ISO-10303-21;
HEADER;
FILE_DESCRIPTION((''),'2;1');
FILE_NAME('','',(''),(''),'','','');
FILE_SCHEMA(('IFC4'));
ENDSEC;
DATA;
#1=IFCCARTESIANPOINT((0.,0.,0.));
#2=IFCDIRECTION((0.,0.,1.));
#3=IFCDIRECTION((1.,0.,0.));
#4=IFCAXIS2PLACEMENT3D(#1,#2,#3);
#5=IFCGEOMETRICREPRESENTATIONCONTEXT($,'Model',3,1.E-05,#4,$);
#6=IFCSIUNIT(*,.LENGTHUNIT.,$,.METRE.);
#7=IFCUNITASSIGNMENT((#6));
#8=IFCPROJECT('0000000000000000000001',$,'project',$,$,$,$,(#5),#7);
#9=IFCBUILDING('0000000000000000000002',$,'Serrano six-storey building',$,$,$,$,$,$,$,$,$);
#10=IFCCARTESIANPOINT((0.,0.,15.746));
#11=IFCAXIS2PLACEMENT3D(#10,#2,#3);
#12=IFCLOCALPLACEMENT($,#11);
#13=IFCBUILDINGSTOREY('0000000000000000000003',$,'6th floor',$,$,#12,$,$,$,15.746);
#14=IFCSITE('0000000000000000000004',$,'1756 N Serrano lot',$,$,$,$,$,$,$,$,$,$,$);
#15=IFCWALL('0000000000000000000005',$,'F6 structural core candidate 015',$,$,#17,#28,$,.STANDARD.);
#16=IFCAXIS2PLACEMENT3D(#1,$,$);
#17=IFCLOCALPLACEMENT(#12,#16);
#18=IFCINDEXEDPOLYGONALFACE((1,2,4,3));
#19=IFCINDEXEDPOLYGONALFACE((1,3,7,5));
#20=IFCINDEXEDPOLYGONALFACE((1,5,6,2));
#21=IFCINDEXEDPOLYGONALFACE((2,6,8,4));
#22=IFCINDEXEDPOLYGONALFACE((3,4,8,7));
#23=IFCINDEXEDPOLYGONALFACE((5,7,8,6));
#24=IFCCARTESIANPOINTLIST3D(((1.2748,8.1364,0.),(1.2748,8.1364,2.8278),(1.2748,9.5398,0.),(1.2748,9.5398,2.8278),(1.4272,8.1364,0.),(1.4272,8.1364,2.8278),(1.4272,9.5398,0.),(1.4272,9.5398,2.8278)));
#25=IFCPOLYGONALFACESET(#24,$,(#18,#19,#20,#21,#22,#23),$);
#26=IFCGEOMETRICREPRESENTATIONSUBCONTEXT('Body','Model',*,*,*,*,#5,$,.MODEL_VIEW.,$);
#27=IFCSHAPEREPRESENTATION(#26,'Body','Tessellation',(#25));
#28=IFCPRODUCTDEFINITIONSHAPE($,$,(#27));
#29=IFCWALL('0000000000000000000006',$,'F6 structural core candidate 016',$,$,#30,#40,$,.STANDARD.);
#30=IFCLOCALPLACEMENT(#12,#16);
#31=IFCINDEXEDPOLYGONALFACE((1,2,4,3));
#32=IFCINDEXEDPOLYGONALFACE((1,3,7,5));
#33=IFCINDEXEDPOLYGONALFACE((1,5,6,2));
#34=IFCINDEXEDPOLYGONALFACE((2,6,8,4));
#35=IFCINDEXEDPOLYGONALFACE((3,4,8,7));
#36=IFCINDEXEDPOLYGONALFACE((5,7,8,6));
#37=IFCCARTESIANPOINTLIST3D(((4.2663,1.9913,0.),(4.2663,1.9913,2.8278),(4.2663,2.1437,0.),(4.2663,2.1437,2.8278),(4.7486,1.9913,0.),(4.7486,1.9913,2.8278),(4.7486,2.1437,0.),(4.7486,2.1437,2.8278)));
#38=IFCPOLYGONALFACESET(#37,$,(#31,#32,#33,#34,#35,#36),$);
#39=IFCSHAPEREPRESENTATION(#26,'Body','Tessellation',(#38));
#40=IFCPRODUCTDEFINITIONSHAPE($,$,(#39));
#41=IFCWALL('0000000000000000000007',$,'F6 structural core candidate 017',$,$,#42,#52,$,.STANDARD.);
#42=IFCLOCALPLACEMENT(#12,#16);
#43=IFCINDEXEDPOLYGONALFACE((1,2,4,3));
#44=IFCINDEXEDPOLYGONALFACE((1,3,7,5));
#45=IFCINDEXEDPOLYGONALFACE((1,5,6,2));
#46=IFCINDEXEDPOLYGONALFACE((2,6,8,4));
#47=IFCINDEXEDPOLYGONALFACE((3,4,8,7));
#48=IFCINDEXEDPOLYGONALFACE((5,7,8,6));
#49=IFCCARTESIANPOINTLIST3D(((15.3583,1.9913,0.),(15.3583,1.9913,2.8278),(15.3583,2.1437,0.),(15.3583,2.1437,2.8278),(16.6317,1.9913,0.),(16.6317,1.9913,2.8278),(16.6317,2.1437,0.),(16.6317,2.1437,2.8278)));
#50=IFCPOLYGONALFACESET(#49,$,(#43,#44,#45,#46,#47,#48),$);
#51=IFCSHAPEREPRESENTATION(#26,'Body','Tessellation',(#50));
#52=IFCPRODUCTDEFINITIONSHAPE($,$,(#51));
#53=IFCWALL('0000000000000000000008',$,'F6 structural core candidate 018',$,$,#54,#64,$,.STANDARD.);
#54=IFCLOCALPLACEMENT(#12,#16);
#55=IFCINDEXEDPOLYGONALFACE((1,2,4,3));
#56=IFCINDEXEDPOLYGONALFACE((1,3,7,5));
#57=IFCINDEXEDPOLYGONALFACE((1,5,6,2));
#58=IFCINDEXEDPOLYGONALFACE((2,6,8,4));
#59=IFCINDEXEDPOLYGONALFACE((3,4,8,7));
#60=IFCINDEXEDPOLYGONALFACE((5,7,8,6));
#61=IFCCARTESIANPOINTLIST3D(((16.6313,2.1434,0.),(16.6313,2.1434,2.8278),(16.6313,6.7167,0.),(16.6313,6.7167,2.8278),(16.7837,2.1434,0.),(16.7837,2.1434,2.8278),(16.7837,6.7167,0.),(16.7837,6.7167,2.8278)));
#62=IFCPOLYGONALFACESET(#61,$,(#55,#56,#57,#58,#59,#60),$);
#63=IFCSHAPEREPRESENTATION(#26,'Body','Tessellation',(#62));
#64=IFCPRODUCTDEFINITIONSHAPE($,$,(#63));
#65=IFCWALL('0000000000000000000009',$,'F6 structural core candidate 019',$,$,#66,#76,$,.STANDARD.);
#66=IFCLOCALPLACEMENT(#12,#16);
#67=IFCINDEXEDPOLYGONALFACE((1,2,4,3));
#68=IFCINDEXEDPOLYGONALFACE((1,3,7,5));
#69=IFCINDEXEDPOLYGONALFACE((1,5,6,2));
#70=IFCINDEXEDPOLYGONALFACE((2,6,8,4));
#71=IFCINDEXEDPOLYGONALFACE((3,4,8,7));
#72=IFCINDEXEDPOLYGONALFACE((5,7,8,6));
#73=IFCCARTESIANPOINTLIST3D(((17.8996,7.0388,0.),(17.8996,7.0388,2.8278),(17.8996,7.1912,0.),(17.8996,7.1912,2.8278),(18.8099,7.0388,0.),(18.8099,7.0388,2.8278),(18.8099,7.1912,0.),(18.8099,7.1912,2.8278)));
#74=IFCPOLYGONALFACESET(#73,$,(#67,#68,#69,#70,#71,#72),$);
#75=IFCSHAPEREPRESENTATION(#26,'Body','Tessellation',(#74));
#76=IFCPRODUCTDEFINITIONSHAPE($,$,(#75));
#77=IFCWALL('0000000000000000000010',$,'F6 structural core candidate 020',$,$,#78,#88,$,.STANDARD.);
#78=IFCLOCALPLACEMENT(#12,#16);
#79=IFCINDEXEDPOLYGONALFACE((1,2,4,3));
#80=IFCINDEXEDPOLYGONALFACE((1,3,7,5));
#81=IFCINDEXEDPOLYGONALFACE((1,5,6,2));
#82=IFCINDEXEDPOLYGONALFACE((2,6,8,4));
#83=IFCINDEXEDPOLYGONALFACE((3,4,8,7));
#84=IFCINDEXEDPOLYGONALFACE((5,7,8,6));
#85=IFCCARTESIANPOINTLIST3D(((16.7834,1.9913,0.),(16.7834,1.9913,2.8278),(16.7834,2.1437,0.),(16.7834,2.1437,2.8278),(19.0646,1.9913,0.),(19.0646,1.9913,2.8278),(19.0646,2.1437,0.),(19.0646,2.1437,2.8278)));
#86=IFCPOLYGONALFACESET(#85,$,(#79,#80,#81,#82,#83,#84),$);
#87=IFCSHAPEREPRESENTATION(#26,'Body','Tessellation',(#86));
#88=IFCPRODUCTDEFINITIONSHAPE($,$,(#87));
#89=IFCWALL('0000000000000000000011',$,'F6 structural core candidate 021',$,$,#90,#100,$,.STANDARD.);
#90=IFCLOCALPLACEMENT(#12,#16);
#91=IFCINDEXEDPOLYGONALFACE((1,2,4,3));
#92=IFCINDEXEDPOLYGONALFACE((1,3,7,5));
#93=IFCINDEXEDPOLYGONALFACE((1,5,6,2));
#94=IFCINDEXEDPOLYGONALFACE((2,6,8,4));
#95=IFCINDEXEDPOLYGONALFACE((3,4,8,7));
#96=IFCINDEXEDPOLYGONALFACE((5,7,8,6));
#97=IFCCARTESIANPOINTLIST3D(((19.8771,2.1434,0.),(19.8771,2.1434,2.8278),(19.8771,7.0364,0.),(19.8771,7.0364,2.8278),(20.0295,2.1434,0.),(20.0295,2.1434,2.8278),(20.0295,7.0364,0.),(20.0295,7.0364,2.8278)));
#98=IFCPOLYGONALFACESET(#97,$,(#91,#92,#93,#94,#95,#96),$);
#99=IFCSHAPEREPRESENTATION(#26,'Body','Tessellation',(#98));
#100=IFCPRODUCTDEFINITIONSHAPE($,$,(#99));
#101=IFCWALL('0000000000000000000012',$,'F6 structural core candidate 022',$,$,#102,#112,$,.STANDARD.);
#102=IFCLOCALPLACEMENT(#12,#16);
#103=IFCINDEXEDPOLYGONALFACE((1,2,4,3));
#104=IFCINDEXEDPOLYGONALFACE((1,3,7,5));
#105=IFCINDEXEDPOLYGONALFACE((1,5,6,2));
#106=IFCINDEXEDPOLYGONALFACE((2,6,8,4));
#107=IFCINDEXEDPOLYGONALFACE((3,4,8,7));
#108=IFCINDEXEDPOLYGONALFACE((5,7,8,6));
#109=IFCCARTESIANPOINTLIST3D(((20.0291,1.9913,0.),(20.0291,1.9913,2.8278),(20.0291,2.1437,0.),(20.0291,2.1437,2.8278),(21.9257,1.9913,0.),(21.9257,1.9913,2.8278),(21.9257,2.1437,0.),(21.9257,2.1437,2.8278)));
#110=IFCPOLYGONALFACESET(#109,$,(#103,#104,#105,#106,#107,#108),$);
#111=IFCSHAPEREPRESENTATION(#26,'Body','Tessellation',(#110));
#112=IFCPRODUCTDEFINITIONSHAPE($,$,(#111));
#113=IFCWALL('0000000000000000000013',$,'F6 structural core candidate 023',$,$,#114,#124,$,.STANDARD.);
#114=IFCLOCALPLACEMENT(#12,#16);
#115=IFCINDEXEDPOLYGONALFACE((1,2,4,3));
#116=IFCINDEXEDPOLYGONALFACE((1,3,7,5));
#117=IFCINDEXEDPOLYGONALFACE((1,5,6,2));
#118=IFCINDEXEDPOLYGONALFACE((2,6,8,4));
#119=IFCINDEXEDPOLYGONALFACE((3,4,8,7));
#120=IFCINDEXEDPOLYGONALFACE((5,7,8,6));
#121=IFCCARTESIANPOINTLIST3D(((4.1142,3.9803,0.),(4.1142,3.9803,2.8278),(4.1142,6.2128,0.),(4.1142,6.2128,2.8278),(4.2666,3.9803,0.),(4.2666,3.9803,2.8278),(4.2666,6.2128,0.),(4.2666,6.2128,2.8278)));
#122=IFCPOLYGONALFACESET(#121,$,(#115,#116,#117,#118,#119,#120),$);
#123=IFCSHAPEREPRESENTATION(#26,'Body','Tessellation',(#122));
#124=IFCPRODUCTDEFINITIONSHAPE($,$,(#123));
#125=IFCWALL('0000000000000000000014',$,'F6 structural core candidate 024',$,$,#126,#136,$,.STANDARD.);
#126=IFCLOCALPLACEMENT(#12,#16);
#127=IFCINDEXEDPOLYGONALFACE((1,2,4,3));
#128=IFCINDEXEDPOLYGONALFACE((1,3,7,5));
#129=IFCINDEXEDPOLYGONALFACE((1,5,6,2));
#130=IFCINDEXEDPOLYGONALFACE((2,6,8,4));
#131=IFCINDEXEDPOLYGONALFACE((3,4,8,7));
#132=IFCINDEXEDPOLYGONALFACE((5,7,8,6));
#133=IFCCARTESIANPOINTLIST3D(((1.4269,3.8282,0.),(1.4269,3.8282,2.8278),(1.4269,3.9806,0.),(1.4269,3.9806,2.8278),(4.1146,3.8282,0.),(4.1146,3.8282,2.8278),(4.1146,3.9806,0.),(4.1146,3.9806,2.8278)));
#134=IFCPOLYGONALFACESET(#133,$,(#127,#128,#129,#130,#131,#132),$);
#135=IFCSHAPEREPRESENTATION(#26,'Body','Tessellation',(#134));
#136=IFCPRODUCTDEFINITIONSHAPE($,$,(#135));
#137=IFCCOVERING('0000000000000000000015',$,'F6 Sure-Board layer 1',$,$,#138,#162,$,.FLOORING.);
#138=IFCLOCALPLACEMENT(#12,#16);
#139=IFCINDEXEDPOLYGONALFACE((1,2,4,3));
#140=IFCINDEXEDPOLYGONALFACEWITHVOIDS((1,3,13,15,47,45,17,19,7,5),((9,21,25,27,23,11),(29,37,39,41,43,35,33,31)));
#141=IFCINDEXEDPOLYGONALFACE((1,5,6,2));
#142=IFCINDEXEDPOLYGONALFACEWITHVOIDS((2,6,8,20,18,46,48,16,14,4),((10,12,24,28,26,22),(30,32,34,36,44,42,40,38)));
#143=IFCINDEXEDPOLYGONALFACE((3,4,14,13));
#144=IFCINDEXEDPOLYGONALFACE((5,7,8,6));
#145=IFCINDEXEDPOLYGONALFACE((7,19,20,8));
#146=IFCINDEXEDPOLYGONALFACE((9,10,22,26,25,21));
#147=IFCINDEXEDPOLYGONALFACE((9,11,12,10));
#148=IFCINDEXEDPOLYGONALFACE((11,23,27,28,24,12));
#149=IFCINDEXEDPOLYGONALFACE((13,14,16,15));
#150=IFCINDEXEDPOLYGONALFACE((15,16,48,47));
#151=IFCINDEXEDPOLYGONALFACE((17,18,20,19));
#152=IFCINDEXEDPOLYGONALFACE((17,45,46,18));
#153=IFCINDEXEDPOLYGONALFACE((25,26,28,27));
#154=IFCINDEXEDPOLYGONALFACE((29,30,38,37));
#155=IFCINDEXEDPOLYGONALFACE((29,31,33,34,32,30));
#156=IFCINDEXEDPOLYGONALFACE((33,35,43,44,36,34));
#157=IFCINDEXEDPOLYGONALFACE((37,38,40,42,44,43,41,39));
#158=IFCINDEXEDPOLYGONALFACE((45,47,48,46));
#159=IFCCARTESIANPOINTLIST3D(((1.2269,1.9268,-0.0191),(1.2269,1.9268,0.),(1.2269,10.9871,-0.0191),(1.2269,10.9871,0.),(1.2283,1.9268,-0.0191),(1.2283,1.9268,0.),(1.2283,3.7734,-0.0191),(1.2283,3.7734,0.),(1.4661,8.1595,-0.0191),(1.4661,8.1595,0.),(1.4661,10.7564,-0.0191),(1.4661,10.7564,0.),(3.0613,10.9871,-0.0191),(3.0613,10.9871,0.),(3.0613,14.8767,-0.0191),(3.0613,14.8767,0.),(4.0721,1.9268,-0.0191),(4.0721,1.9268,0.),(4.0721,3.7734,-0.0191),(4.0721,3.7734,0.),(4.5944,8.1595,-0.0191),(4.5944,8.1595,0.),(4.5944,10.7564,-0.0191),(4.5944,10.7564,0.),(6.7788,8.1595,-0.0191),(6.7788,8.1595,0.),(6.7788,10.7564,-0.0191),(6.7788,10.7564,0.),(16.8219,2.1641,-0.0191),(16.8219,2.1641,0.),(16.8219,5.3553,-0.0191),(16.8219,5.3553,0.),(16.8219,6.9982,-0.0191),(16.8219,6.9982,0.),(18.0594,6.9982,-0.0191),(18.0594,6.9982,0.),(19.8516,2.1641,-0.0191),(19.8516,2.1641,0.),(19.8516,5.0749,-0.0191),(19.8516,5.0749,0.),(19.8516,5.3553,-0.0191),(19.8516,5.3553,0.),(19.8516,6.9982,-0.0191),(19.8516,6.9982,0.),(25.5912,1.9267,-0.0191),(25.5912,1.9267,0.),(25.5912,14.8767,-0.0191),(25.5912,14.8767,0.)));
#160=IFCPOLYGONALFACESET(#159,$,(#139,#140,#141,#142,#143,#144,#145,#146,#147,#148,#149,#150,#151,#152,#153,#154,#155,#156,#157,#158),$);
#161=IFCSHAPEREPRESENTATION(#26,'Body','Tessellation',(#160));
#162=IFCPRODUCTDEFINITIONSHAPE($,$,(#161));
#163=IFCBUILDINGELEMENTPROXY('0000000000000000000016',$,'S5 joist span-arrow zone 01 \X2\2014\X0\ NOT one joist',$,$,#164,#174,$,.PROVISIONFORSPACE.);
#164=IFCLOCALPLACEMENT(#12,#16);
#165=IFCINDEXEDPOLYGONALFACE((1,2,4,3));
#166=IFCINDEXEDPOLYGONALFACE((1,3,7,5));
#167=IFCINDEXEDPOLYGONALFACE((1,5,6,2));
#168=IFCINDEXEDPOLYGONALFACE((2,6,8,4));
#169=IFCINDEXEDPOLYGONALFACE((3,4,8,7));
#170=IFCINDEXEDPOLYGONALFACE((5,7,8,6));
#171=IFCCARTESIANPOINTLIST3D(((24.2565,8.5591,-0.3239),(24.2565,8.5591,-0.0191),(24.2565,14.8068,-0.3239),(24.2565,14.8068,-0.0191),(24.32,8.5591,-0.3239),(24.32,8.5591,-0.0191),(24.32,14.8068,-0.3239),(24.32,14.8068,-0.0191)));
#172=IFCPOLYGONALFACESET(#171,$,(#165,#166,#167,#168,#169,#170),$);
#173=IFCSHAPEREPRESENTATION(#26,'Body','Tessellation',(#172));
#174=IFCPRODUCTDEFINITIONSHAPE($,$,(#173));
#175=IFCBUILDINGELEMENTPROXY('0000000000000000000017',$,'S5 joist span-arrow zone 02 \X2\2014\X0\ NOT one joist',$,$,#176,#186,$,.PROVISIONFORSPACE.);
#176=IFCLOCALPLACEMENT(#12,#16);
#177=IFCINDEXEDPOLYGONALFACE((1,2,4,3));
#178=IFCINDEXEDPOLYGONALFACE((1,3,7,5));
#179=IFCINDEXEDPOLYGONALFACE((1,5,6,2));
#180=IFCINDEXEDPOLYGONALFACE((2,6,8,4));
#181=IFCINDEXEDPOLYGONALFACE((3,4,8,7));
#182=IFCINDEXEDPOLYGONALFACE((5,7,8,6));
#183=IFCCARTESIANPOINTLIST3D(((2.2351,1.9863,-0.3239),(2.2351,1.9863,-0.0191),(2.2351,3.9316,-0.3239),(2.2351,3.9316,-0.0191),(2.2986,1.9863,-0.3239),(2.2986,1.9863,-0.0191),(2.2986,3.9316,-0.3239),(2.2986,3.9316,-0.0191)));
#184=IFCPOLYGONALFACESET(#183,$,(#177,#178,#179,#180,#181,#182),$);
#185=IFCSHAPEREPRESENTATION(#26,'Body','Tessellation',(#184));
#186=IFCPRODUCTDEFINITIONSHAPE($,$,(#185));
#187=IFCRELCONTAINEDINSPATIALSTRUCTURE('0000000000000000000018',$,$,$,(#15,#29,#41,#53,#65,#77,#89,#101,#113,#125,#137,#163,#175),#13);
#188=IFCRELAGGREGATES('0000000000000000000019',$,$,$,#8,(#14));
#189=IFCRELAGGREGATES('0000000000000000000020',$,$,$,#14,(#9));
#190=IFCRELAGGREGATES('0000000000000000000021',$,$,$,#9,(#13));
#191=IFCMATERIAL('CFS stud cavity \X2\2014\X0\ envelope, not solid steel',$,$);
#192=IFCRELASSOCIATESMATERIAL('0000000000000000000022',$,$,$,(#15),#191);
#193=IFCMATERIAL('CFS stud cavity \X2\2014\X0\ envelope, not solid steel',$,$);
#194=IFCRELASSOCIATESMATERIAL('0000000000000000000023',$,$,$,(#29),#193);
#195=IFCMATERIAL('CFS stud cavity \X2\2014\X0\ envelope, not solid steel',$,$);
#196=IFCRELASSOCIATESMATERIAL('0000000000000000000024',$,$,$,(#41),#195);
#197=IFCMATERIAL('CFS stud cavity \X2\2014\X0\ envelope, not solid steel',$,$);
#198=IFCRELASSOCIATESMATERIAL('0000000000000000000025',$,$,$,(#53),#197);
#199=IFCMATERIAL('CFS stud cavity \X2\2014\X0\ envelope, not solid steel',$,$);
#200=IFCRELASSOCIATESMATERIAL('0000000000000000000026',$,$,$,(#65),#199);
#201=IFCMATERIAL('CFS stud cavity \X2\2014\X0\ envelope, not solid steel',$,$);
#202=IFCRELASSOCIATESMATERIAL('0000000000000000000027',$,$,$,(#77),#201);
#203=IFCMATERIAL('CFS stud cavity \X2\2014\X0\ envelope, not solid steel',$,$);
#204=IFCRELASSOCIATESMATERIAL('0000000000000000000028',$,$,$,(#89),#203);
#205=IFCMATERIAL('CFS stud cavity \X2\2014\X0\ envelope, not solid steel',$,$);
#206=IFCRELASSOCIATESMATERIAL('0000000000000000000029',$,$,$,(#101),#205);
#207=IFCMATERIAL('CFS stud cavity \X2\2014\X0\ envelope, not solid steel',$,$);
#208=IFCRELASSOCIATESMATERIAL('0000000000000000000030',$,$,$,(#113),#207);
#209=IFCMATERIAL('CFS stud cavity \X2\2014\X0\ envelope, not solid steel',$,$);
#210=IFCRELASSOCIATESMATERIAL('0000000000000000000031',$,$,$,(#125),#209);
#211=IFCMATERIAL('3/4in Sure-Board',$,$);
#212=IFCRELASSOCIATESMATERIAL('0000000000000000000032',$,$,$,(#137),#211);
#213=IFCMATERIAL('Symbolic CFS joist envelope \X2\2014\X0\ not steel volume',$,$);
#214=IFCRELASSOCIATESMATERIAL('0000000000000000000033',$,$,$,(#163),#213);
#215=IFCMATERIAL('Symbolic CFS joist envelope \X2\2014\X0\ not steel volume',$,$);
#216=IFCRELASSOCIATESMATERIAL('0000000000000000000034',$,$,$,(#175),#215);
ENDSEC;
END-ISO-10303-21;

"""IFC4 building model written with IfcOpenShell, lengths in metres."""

from ifc_helpers import new_model, si_unit, frame, origin_with_axes, place, context, subcontext, project, spatial, polyline, outline, extrude, material, element, save


model = new_model("IFC4")

# Units and contexts
model_context = context("Model", 3, precision=1e-05, world=origin_with_axes())
body_context = subcontext(model_context, "Body", "Model", "MODEL_VIEW")
ifc_project = project(units=[si_unit("LENGTHUNIT", "METRE")], contexts=[model_context])

# Site, building, storey
site = spatial("IfcSite", under=ifc_project, Name="1756 N Serrano lot")
building = spatial("IfcBuilding", under=site, Name="Serrano six-storey building")
storey_placement = place(None, frame((0.0, 0.0, 15.746), z_axis=(0.0, 0.0, 1.0), x_axis=(1.0, 0.0, 0.0)))
storey = spatial("IfcBuildingStorey", under=building, at=storey_placement, Name="6th floor", Elevation=15.746)

# Walls
ifc_material_1 = material(Name="CFS stud cavity — envelope, not solid steel")
wall_1_placement = place(storey_placement, frame((0.0, 0.0, -15.746), z_axis=(0.0, 0.0, 1.0), x_axis=(1.0, 0.0, 0.0)))
element("IfcWall", 1, at=wall_1_placement, inside=storey, material=ifc_material_1, Name="F6 structural core candidate 015", PredefinedType="STANDARD", context=body_context, shape_type="SweptSolid", body=[
    extrude(outline(polyline([(1.4272, 8.1364), (1.2748, 8.1364), (1.2748, 9.5398), (1.4272, 9.5398), (1.4272, 8.1364)])), frame((0.0, 0.0, 15.746)), (0.0, 0.0, 1.0), 2.8278),
])
ifc_material_2 = material(Name="CFS stud cavity — envelope, not solid steel")
wall_2_placement = place(storey_placement, frame((0.0, 0.0, -15.746), z_axis=(0.0, 0.0, 1.0), x_axis=(1.0, 0.0, 0.0)))
element("IfcWall", 2, at=wall_2_placement, inside=storey, material=ifc_material_2, Name="F6 structural core candidate 016", PredefinedType="STANDARD", context=body_context, shape_type="SweptSolid", body=[
    extrude(outline(polyline([(4.7486, 2.1437), (4.7486, 1.9913), (4.2663, 1.9913), (4.2663, 2.1437), (4.7486, 2.1437)])), frame((0.0, 0.0, 15.746)), (0.0, 0.0, 1.0), 2.8278),
])
ifc_material_3 = material(Name="CFS stud cavity — envelope, not solid steel")
wall_3_placement = place(storey_placement, frame((0.0, 0.0, -15.746), z_axis=(0.0, 0.0, 1.0), x_axis=(1.0, 0.0, 0.0)))
element("IfcWall", 3, at=wall_3_placement, inside=storey, material=ifc_material_3, Name="F6 structural core candidate 017", PredefinedType="STANDARD", context=body_context, shape_type="SweptSolid", body=[
    extrude(outline(polyline([(16.6317, 2.1437), (16.6317, 1.9913), (15.3583, 1.9913), (15.3583, 2.1437), (16.6317, 2.1437)])), frame((0.0, 0.0, 15.746)), (0.0, 0.0, 1.0), 2.8278),
])
ifc_material_4 = material(Name="CFS stud cavity — envelope, not solid steel")
wall_4_placement = place(storey_placement, frame((0.0, 0.0, -15.746), z_axis=(0.0, 0.0, 1.0), x_axis=(1.0, 0.0, 0.0)))
element("IfcWall", 4, at=wall_4_placement, inside=storey, material=ifc_material_4, Name="F6 structural core candidate 018", PredefinedType="STANDARD", context=body_context, shape_type="SweptSolid", body=[
    extrude(outline(polyline([(16.7837, 2.1434), (16.6313, 2.1434), (16.6313, 6.7167), (16.7837, 6.7167), (16.7837, 2.1434)])), frame((0.0, 0.0, 15.746)), (0.0, 0.0, 1.0), 2.8278),
])
ifc_material_5 = material(Name="CFS stud cavity — envelope, not solid steel")
wall_5_placement = place(storey_placement, frame((0.0, 0.0, -15.746), z_axis=(0.0, 0.0, 1.0), x_axis=(1.0, 0.0, 0.0)))
element("IfcWall", 5, at=wall_5_placement, inside=storey, material=ifc_material_5, Name="F6 structural core candidate 019", PredefinedType="STANDARD", context=body_context, shape_type="SweptSolid", body=[
    extrude(outline(polyline([(18.8099, 7.1912), (18.8099, 7.0388), (17.8996, 7.0388), (17.8996, 7.1912), (18.8099, 7.1912)])), frame((0.0, 0.0, 15.746)), (0.0, 0.0, 1.0), 2.8278),
])
ifc_material_6 = material(Name="CFS stud cavity — envelope, not solid steel")
wall_6_placement = place(storey_placement, frame((0.0, 0.0, -15.746), z_axis=(0.0, 0.0, 1.0), x_axis=(1.0, 0.0, 0.0)))
element("IfcWall", 6, at=wall_6_placement, inside=storey, material=ifc_material_6, Name="F6 structural core candidate 020", PredefinedType="STANDARD", context=body_context, shape_type="SweptSolid", body=[
    extrude(outline(polyline([(19.0646, 2.1437), (19.0646, 1.9913), (16.7834, 1.9913), (16.7834, 2.1437), (19.0646, 2.1437)])), frame((0.0, 0.0, 15.746)), (0.0, 0.0, 1.0), 2.8278),
])
ifc_material_7 = material(Name="CFS stud cavity — envelope, not solid steel")
wall_7_placement = place(storey_placement, frame((0.0, 0.0, -15.746), z_axis=(0.0, 0.0, 1.0), x_axis=(1.0, 0.0, 0.0)))
element("IfcWall", 7, at=wall_7_placement, inside=storey, material=ifc_material_7, Name="F6 structural core candidate 021", PredefinedType="STANDARD", context=body_context, shape_type="SweptSolid", body=[
    extrude(outline(polyline([(20.0295, 2.1434), (19.8771, 2.1434), (19.8771, 7.0364), (20.0295, 7.0364), (20.0295, 2.1434)])), frame((0.0, 0.0, 15.746)), (0.0, 0.0, 1.0), 2.8278),
])
ifc_material_8 = material(Name="CFS stud cavity — envelope, not solid steel")
wall_8_placement = place(storey_placement, frame((0.0, 0.0, -15.746), z_axis=(0.0, 0.0, 1.0), x_axis=(1.0, 0.0, 0.0)))
element("IfcWall", 8, at=wall_8_placement, inside=storey, material=ifc_material_8, Name="F6 structural core candidate 022", PredefinedType="STANDARD", context=body_context, shape_type="SweptSolid", body=[
    extrude(outline(polyline([(21.9257, 2.1437), (21.9257, 1.9913), (20.0291, 1.9913), (20.0291, 2.1437), (21.9257, 2.1437)])), frame((0.0, 0.0, 15.746)), (0.0, 0.0, 1.0), 2.8278),
])
ifc_material_9 = material(Name="CFS stud cavity — envelope, not solid steel")
wall_9_placement = place(storey_placement, frame((0.0, 0.0, -15.746), z_axis=(0.0, 0.0, 1.0), x_axis=(1.0, 0.0, 0.0)))
element("IfcWall", 9, at=wall_9_placement, inside=storey, material=ifc_material_9, Name="F6 structural core candidate 023", PredefinedType="STANDARD", context=body_context, shape_type="SweptSolid", body=[
    extrude(outline(polyline([(4.2666, 3.9803), (4.1142, 3.9803), (4.1142, 6.2128), (4.2666, 6.2128), (4.2666, 3.9803)])), frame((0.0, 0.0, 15.746)), (0.0, 0.0, 1.0), 2.8278),
])
ifc_material_10 = material(Name="CFS stud cavity — envelope, not solid steel")
wall_10_placement = place(storey_placement, frame((0.0, 0.0, -15.746), z_axis=(0.0, 0.0, 1.0), x_axis=(1.0, 0.0, 0.0)))
element("IfcWall", 10, at=wall_10_placement, inside=storey, material=ifc_material_10, Name="F6 structural core candidate 024", PredefinedType="STANDARD", context=body_context, shape_type="SweptSolid", body=[
    extrude(outline(polyline([(4.1146, 3.9806), (4.1146, 3.8282), (1.4269, 3.8282), (1.4269, 3.9806), (4.1146, 3.9806)])), frame((0.0, 0.0, 15.746)), (0.0, 0.0, 1.0), 2.8278),
])

# Covering
ifc_material_11 = material(Name="3/4in Sure-Board")
covering_placement = place(storey_placement, frame((0.0, 0.0, -15.746), z_axis=(0.0, 0.0, 1.0), x_axis=(1.0, 0.0, 0.0)))
element("IfcCovering", 11, at=covering_placement, inside=storey, material=ifc_material_11, Name="F6 Sure-Board layer 1", PredefinedType="FLOORING", context=body_context, shape_type="SweptSolid", body=[
    extrude(outline(polyline([(3.0613, 14.8767), (25.5912, 14.8767), (25.5912, 1.9267), (4.0721, 1.9268), (4.0721, 3.7734), (1.2283, 3.7734), (1.2283, 1.9268), (1.2269, 1.9268), (1.2269, 10.9871), (3.0613, 10.9871), (3.0613, 14.8767)]), holes=[polyline([(6.7788, 10.7564), (4.5944, 10.7564), (1.4661, 10.7564), (1.4661, 8.1595), (4.5944, 8.1595), (6.7788, 8.1595), (6.7788, 10.7564)]), polyline([(16.8219, 5.3553), (16.8219, 2.1641), (19.8516, 2.1641), (19.8516, 5.0749), (19.8516, 5.3553), (19.8516, 6.9982), (18.0594, 6.9982), (16.8219, 6.9982), (16.8219, 5.3553)])]), frame((0.0, 0.0, 15.7269)), (0.0, 0.0, 1.0), 0.0191),
])

# Building element proxies
ifc_material_12 = material(Name="Symbolic CFS joist envelope — not steel volume")
proxy_1_placement = place(storey_placement, frame((0.0, 0.0, -15.746), z_axis=(0.0, 0.0, 1.0), x_axis=(1.0, 0.0, 0.0)))
element("IfcBuildingElementProxy", 12, at=proxy_1_placement, inside=storey, material=ifc_material_12, Name="S5 joist span-arrow zone 01 — NOT one joist", PredefinedType="PROVISIONFORSPACE", context=body_context, shape_type="SweptSolid", body=[
    extrude(outline(polyline([(24.2565, 14.8068), (24.32, 14.8068), (24.32, 8.5591), (24.2565, 8.5591), (24.2565, 14.8068)])), frame((0.0, 0.0, 15.4221)), (0.0, 0.0, 1.0), 0.3048),
])
ifc_material_13 = material(Name="Symbolic CFS joist envelope — not steel volume")
proxy_2_placement = place(storey_placement, frame((0.0, 0.0, -15.746), z_axis=(0.0, 0.0, 1.0), x_axis=(1.0, 0.0, 0.0)))
element("IfcBuildingElementProxy", 13, at=proxy_2_placement, inside=storey, material=ifc_material_13, Name="S5 joist span-arrow zone 02 — NOT one joist", PredefinedType="PROVISIONFORSPACE", context=body_context, shape_type="SweptSolid", body=[
    extrude(outline(polyline([(2.2351, 3.9316), (2.2986, 3.9316), (2.2986, 1.9863), (2.2351, 1.9863), (2.2351, 3.9316)])), frame((0.0, 0.0, 15.4221)), (0.0, 0.0, 1.0), 0.3048),
])

save(model, "model.ifc")
